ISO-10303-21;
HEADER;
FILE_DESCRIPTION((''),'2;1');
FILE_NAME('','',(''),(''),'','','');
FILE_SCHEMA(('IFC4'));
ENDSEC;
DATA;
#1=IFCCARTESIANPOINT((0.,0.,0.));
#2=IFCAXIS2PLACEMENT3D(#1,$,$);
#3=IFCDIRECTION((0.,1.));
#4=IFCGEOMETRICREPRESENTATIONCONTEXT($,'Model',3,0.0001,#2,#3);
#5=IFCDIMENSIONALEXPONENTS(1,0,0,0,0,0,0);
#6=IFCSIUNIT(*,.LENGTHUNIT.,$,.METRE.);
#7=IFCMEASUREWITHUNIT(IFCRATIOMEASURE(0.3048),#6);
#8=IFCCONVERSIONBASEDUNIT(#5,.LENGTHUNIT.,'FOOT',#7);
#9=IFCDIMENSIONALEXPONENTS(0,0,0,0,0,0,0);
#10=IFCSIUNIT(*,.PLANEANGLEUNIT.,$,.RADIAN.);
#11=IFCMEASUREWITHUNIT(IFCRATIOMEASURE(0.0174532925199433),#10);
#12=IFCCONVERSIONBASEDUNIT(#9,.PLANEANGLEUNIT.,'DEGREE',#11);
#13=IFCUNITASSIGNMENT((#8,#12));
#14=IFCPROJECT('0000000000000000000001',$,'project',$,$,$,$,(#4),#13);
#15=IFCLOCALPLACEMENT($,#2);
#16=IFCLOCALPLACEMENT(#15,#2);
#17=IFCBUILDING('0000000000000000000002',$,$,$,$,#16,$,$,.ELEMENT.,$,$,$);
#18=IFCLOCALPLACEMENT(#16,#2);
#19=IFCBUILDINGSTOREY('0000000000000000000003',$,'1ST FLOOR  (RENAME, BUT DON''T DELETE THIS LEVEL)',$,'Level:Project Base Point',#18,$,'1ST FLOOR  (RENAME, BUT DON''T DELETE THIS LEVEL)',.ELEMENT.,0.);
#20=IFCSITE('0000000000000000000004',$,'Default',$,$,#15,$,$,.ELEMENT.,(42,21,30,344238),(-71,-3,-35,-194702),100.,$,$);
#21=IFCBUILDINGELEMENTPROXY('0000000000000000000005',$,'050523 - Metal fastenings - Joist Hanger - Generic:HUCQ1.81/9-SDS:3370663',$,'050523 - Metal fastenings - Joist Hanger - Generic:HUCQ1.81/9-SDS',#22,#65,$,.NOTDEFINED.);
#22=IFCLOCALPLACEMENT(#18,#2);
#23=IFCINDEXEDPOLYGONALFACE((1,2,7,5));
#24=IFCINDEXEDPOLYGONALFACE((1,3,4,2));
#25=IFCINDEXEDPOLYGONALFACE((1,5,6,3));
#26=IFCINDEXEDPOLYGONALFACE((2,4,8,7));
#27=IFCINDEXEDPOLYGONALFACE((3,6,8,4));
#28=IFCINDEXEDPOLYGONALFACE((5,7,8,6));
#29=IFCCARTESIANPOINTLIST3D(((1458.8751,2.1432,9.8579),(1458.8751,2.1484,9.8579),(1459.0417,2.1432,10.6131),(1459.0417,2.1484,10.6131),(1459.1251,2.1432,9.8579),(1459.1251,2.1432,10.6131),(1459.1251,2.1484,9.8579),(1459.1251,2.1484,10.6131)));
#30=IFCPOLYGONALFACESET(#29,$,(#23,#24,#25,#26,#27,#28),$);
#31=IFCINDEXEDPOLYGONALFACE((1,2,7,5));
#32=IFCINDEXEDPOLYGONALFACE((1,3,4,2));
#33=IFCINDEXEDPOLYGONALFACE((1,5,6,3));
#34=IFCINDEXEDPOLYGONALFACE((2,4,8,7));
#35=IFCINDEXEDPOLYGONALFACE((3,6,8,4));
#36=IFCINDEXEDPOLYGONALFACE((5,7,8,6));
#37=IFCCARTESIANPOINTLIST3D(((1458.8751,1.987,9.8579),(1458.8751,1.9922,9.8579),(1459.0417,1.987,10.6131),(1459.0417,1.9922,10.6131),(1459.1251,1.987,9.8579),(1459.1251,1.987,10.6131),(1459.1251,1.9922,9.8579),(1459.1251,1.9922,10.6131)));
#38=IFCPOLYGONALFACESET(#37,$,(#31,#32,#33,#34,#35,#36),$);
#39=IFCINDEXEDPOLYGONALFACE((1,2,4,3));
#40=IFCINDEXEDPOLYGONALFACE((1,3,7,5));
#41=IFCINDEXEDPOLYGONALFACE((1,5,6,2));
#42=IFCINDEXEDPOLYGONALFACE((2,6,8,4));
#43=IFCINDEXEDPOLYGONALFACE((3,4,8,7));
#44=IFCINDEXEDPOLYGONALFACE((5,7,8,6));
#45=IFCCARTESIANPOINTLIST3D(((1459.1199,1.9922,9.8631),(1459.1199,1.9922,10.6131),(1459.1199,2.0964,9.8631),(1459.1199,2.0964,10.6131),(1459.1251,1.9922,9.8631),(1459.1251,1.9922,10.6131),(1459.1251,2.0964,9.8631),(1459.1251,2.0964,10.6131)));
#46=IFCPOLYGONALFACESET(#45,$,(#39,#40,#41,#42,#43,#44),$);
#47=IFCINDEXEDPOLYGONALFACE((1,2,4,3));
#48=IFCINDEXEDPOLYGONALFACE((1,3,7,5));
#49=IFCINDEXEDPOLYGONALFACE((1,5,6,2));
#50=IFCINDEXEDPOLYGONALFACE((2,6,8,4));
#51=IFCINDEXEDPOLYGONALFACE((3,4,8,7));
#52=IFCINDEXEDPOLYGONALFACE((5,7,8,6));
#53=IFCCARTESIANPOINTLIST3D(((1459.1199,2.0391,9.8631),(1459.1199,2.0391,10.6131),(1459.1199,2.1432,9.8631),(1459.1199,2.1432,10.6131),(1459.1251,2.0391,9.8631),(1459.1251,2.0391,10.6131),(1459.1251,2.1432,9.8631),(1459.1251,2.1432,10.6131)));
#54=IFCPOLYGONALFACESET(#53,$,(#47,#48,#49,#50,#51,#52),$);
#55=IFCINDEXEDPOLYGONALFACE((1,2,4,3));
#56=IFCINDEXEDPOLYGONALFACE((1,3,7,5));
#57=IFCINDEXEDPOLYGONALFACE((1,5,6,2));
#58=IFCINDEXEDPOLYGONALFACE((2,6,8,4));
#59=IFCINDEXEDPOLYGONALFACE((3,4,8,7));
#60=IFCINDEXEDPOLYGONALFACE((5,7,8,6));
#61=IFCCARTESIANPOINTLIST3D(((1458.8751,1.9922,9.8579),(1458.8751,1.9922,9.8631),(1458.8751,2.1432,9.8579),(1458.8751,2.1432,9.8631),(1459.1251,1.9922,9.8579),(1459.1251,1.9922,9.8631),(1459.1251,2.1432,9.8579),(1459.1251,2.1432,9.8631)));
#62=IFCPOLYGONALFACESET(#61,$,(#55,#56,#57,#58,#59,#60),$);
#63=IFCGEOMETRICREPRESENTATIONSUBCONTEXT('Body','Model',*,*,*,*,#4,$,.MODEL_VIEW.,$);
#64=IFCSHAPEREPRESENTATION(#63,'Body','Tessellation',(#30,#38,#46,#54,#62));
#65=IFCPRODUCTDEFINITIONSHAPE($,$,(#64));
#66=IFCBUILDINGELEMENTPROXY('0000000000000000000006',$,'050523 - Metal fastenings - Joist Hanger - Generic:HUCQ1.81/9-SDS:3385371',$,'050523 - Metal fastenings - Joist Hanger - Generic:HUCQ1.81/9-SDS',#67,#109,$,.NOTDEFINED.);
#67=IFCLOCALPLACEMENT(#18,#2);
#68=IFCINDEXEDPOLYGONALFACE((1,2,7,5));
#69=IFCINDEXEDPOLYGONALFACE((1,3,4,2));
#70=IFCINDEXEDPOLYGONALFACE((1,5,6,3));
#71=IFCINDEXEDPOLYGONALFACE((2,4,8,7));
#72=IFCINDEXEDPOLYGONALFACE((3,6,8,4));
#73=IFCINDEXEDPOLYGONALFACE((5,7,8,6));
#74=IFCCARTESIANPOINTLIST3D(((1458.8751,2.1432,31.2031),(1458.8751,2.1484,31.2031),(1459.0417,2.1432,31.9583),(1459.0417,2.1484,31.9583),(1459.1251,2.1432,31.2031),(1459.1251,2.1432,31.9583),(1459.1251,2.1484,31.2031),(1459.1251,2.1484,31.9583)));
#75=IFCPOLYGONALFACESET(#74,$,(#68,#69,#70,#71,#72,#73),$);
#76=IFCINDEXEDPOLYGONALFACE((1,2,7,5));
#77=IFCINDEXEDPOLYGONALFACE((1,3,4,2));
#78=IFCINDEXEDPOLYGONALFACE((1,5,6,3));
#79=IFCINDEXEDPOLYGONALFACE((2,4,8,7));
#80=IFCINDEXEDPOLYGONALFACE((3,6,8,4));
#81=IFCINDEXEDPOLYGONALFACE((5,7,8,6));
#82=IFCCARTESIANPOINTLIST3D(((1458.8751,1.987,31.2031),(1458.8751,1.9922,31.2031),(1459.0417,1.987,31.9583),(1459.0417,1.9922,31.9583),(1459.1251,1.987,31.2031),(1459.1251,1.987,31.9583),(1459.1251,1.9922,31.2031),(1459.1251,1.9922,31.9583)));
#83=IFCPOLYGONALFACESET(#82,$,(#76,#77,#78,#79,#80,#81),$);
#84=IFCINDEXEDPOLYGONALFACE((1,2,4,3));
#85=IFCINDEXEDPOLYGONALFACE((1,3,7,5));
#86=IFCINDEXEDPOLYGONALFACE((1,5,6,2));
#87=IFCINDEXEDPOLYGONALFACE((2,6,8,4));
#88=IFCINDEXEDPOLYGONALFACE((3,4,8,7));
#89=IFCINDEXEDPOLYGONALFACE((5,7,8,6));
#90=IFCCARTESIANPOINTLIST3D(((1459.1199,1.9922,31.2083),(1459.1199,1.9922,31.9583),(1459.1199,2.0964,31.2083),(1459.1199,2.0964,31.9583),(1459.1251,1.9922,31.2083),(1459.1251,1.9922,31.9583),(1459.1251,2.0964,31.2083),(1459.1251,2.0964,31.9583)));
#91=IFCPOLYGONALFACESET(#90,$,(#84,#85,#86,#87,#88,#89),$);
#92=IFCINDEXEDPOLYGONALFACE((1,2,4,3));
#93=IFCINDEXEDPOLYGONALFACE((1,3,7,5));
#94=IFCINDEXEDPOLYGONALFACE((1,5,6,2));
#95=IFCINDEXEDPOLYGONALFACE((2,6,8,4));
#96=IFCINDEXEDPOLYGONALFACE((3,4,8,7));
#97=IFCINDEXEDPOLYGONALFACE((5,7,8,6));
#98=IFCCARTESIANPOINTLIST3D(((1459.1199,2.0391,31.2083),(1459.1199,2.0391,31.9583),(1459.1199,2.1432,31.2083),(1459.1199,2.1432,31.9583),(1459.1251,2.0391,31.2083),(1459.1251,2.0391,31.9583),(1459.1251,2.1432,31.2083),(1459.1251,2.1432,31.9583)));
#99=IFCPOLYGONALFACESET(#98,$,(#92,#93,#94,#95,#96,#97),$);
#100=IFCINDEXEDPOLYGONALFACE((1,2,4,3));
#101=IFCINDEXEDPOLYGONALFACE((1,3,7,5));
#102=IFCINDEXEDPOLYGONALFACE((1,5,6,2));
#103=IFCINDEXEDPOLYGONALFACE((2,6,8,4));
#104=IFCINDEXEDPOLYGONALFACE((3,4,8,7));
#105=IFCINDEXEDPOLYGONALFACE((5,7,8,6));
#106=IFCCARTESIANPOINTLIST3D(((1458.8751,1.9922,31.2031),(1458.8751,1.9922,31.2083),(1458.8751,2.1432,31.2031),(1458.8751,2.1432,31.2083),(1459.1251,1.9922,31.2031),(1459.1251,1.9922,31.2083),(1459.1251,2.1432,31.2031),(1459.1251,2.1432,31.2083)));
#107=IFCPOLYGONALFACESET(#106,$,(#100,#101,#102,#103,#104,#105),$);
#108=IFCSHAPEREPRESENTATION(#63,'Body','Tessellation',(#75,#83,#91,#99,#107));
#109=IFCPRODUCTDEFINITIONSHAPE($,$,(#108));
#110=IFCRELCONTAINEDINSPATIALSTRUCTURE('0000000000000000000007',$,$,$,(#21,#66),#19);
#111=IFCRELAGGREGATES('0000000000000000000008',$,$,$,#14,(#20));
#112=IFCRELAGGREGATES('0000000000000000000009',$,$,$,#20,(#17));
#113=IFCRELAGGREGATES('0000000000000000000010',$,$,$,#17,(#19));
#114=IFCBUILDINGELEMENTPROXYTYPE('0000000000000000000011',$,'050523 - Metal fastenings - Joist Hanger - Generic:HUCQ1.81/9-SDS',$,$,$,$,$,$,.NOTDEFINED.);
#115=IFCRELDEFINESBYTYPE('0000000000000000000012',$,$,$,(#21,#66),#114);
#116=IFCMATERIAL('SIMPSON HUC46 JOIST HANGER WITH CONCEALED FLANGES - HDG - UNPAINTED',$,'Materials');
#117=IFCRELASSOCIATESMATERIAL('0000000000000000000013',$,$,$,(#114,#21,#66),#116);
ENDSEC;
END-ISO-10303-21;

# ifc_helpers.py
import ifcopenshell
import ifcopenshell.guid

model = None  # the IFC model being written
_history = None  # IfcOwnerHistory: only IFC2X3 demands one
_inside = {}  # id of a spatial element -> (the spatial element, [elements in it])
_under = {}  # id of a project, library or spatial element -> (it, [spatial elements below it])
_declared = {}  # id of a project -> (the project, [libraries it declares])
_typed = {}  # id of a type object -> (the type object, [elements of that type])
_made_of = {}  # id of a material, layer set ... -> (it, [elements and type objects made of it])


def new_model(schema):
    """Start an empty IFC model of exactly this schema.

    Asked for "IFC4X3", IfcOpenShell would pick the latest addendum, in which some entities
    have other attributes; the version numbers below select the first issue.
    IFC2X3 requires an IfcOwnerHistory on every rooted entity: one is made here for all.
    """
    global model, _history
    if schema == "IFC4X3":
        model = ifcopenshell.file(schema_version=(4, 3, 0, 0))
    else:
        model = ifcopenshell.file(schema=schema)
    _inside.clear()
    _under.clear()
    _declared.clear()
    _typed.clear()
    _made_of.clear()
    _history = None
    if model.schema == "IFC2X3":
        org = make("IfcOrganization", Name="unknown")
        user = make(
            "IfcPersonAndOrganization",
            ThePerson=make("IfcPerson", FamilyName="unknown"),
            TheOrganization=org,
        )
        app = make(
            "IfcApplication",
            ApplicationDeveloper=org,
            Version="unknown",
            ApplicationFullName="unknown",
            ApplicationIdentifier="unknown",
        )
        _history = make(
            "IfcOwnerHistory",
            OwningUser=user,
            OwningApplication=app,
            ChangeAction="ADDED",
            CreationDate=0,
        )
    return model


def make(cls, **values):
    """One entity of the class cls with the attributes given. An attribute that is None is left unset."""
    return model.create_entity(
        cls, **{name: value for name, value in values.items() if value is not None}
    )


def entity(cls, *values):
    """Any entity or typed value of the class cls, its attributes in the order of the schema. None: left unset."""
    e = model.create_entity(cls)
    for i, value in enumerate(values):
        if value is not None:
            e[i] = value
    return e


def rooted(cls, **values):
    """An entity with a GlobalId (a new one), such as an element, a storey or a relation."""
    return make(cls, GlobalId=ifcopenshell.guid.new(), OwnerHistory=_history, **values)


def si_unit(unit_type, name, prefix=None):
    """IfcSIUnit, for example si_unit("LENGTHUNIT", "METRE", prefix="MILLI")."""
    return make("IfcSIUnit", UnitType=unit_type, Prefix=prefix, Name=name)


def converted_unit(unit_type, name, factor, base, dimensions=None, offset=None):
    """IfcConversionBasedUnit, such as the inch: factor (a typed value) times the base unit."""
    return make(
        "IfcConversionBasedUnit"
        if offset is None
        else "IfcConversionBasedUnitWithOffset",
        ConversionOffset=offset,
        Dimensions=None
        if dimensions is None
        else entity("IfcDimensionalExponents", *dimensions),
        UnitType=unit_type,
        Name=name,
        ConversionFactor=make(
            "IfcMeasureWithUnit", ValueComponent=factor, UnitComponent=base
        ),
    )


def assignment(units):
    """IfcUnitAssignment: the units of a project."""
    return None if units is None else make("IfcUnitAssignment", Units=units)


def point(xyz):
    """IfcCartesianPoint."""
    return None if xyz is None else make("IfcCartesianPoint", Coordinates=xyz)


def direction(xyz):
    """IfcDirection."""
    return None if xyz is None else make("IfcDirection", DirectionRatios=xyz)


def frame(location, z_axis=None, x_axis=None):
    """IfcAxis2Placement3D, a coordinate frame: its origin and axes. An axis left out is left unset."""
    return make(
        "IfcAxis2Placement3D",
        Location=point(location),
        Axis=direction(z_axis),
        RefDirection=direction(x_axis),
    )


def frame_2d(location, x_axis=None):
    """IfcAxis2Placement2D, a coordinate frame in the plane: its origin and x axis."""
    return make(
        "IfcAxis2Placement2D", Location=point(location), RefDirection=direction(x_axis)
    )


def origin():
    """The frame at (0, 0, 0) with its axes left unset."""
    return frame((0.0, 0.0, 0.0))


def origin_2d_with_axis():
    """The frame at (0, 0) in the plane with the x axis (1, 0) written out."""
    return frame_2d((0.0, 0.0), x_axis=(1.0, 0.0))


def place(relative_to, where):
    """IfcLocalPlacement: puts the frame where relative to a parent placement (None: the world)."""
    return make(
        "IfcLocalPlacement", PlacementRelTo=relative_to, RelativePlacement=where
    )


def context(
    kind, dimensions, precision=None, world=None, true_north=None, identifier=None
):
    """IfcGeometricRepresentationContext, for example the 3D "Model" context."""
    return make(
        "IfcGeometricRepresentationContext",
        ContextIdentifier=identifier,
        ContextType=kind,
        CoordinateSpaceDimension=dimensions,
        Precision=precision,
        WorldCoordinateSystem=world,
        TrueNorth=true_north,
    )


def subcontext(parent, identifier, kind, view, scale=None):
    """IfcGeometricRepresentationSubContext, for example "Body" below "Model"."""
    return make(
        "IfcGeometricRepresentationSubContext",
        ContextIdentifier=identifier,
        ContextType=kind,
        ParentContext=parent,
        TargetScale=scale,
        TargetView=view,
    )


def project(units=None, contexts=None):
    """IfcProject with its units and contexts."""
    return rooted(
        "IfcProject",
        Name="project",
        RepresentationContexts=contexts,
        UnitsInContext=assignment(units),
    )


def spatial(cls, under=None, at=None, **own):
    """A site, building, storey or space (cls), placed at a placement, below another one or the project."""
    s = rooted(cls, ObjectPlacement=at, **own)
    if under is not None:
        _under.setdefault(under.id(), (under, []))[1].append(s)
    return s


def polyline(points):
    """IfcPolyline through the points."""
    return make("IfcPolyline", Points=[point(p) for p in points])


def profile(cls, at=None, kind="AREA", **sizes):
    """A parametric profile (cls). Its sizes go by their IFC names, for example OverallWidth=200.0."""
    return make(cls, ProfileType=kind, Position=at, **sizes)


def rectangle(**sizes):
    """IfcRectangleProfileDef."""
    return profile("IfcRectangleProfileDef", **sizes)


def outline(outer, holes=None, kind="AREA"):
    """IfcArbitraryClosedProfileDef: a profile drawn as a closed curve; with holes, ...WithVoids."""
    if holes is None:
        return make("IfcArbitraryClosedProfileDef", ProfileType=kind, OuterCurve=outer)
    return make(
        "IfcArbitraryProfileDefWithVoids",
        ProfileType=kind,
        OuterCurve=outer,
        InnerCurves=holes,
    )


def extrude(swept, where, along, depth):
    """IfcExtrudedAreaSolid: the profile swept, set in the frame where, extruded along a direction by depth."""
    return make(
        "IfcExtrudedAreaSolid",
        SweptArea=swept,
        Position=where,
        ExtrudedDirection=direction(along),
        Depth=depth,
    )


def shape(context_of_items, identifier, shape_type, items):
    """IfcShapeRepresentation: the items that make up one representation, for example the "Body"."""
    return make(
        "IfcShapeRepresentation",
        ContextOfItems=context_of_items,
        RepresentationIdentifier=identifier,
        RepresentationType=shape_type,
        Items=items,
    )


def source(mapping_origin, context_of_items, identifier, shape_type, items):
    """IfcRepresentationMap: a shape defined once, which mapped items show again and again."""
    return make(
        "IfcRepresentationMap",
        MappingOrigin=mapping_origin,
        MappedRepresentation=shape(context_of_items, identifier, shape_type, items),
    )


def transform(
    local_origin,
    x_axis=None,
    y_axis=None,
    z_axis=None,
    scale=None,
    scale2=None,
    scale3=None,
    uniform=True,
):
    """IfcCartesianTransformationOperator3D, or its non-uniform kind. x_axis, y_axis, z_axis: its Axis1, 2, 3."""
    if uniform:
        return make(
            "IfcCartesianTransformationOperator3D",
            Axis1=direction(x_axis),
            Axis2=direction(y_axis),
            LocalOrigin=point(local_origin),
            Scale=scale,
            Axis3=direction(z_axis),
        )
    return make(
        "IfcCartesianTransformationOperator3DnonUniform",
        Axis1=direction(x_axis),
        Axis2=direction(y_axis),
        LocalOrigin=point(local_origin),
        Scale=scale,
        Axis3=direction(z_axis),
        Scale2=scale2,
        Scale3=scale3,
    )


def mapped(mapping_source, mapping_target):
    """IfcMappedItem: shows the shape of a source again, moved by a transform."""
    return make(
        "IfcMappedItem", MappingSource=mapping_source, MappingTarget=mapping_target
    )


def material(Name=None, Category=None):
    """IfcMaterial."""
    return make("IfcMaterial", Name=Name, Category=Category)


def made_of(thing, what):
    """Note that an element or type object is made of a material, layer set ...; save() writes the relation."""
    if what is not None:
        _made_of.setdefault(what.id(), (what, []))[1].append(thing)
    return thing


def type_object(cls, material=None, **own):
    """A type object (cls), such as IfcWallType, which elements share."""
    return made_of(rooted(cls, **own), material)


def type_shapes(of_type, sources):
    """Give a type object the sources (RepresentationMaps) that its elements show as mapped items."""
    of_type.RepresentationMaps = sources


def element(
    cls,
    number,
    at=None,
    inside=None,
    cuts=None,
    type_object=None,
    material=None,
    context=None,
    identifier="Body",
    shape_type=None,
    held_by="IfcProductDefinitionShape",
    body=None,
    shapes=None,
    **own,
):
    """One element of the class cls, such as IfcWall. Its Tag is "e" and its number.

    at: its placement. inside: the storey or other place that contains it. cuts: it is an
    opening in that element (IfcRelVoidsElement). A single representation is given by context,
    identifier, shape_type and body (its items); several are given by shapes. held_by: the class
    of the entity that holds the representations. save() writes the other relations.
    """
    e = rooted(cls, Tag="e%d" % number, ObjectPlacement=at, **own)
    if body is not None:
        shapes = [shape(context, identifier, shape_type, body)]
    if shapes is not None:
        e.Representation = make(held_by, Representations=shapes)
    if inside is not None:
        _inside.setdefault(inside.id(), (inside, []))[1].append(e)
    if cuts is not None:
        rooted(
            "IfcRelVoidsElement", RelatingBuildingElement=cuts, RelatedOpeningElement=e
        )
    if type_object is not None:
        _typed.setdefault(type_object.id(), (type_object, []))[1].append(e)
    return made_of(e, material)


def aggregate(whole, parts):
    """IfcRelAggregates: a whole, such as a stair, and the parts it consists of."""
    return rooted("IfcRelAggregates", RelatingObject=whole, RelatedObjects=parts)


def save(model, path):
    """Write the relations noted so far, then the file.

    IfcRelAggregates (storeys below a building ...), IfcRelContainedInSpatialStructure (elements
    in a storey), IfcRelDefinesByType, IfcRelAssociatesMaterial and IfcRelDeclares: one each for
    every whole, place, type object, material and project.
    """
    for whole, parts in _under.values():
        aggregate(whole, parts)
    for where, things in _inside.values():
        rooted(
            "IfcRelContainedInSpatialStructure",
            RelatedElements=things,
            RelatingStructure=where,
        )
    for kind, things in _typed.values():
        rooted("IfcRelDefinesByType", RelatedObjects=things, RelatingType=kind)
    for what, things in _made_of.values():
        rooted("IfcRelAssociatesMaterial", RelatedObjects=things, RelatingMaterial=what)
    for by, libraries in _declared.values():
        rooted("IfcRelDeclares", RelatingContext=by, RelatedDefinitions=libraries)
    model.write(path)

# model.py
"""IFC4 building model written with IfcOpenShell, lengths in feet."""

from ifc_helpers import new_model, entity, si_unit, converted_unit, direction, frame, frame_2d, origin, origin_2d_with_axis, place, context, subcontext, project, spatial, polyline, rectangle, outline, extrude, source, transform, mapped, material, type_object, type_shapes, element, save


model = new_model("IFC4")

# Units and contexts
model_context = context("Model", 3, precision=0.0001, world=origin(), true_north=direction((0.0, 1.0)))
body_context = subcontext(model_context, "Body", "Model", "MODEL_VIEW")
ifc_project = project(units=[converted_unit("LENGTHUNIT", "FOOT", entity("IfcRatioMeasure", 0.3048), si_unit("LENGTHUNIT", "METRE"), dimensions=[1, 0, 0, 0, 0, 0, 0]), converted_unit("PLANEANGLEUNIT", "DEGREE", entity("IfcRatioMeasure", 0.0174532925199433), si_unit("PLANEANGLEUNIT", "RADIAN"), dimensions=[0, 0, 0, 0, 0, 0, 0])], contexts=[model_context])

# Site, building, storey
site_placement = place(None, origin())
site = spatial("IfcSite", under=ifc_project, at=site_placement, Name="Default", CompositionType="ELEMENT", RefLatitude=(42, 21, 30, 344238), RefLongitude=(-71, -3, -35, -194702), RefElevation=100.0)
building_placement = place(site_placement, origin())
building = spatial("IfcBuilding", under=site, at=building_placement, CompositionType="ELEMENT")
storey_placement = place(building_placement, origin())
storey = spatial("IfcBuildingStorey", under=building, at=storey_placement, Name="1ST FLOOR  (RENAME, BUT DON'T DELETE THIS LEVEL)", ObjectType="Level:Project Base Point", LongName="1ST FLOOR  (RENAME, BUT DON'T DELETE THIS LEVEL)", CompositionType="ELEMENT", Elevation=0.0)

# Building element proxies
ifc_material_1 = material(Name="SIMPSON HUC46 JOIST HANGER WITH CONCEALED FLANGES - HDG - UNPAINTED", Category="Materials")
building_element_proxy_type = type_object("IfcBuildingElementProxyType", Name="050523 - Metal fastenings - Joist Hanger - Generic:HUCQ1.81/9-SDS", PredefinedType="NOTDEFINED", material=ifc_material_1)
shared_shape = source(origin(), body_context, "Body", "SweptSolid", [
    extrude(outline(polyline([(-0.3776, -0.0833), (0.3776, -0.0833), (0.3776, 0.0), (-0.3776, 0.1667), (-0.3776, -0.0833)])), frame((-0.0807, -0.0833, 0.3724), z_axis=(1.0, 0.0, 0.0), x_axis=(0.0, 0.0, 1.0)), (0.0, 0.0, 1.0), 0.0052),
    extrude(outline(polyline([(-0.3776, -0.0833), (0.3776, -0.0833), (0.3776, 0.0), (-0.3776, 0.1667), (-0.3776, -0.0833)])), frame((0.0755, -0.0833, 0.3724), z_axis=(1.0, 0.0, 0.0), x_axis=(0.0, 0.0, 1.0)), (0.0, 0.0, 1.0), 0.0052),
    extrude(rectangle(XDim=0.0052, YDim=0.1042, at=origin_2d_with_axis()), frame((0.0234, -0.0026, 0.0), z_axis=(0.0, 0.0, 1.0), x_axis=(0.0, 1.0, 0.0)), (0.0, 0.0, 1.0), 0.75),
    extrude(rectangle(XDim=0.0052, YDim=0.1042, at=origin_2d_with_axis()), frame((-0.0234, -0.0026, 0.0), z_axis=(0.0, 0.0, 1.0), x_axis=(0.0, 1.0, 0.0)), (0.0, 0.0, 1.0), 0.75),
    extrude(rectangle(XDim=0.25, YDim=0.151, at=frame_2d((0.0, 0.0), x_axis=(1.0, 0.0))), frame((0.0, -0.125, -0.0052), z_axis=(0.0, 0.0, 1.0), x_axis=(0.0, -1.0, 0.0)), (0.0, 0.0, 1.0), 0.0052),
])
type_shapes(building_element_proxy_type, [shared_shape])
for number, where, z_axis, x_axis, name in (
    (1, (1459.1251, 2.0677, 9.8631), (0.0, 0.0, 1.0), (0.0, -1.0, 0.0), "050523 - Metal fastenings - Joist Hanger - Generic:HUCQ1.81/9-SDS:3370663"),
    (2, (1459.1251, 2.0677, 31.2083), (0.0, 0.0, 1.0), (0.0, -1.0, 0.0), "050523 - Metal fastenings - Joist Hanger - Generic:HUCQ1.81/9-SDS:3385371"),
):
    element("IfcBuildingElementProxy", number, at=place(storey_placement, frame(where, z_axis=z_axis, x_axis=x_axis)), inside=storey, type_object=building_element_proxy_type, material=ifc_material_1, Name=name, ObjectType="050523 - Metal fastenings - Joist Hanger - Generic:HUCQ1.81/9-SDS", PredefinedType="NOTDEFINED", context=body_context, shape_type="MappedRepresentation", body=[
        mapped(shared_shape, transform((0.0, 0.0, 0.0), scale=1.0)),
    ])

save(model, "model.ifc")
